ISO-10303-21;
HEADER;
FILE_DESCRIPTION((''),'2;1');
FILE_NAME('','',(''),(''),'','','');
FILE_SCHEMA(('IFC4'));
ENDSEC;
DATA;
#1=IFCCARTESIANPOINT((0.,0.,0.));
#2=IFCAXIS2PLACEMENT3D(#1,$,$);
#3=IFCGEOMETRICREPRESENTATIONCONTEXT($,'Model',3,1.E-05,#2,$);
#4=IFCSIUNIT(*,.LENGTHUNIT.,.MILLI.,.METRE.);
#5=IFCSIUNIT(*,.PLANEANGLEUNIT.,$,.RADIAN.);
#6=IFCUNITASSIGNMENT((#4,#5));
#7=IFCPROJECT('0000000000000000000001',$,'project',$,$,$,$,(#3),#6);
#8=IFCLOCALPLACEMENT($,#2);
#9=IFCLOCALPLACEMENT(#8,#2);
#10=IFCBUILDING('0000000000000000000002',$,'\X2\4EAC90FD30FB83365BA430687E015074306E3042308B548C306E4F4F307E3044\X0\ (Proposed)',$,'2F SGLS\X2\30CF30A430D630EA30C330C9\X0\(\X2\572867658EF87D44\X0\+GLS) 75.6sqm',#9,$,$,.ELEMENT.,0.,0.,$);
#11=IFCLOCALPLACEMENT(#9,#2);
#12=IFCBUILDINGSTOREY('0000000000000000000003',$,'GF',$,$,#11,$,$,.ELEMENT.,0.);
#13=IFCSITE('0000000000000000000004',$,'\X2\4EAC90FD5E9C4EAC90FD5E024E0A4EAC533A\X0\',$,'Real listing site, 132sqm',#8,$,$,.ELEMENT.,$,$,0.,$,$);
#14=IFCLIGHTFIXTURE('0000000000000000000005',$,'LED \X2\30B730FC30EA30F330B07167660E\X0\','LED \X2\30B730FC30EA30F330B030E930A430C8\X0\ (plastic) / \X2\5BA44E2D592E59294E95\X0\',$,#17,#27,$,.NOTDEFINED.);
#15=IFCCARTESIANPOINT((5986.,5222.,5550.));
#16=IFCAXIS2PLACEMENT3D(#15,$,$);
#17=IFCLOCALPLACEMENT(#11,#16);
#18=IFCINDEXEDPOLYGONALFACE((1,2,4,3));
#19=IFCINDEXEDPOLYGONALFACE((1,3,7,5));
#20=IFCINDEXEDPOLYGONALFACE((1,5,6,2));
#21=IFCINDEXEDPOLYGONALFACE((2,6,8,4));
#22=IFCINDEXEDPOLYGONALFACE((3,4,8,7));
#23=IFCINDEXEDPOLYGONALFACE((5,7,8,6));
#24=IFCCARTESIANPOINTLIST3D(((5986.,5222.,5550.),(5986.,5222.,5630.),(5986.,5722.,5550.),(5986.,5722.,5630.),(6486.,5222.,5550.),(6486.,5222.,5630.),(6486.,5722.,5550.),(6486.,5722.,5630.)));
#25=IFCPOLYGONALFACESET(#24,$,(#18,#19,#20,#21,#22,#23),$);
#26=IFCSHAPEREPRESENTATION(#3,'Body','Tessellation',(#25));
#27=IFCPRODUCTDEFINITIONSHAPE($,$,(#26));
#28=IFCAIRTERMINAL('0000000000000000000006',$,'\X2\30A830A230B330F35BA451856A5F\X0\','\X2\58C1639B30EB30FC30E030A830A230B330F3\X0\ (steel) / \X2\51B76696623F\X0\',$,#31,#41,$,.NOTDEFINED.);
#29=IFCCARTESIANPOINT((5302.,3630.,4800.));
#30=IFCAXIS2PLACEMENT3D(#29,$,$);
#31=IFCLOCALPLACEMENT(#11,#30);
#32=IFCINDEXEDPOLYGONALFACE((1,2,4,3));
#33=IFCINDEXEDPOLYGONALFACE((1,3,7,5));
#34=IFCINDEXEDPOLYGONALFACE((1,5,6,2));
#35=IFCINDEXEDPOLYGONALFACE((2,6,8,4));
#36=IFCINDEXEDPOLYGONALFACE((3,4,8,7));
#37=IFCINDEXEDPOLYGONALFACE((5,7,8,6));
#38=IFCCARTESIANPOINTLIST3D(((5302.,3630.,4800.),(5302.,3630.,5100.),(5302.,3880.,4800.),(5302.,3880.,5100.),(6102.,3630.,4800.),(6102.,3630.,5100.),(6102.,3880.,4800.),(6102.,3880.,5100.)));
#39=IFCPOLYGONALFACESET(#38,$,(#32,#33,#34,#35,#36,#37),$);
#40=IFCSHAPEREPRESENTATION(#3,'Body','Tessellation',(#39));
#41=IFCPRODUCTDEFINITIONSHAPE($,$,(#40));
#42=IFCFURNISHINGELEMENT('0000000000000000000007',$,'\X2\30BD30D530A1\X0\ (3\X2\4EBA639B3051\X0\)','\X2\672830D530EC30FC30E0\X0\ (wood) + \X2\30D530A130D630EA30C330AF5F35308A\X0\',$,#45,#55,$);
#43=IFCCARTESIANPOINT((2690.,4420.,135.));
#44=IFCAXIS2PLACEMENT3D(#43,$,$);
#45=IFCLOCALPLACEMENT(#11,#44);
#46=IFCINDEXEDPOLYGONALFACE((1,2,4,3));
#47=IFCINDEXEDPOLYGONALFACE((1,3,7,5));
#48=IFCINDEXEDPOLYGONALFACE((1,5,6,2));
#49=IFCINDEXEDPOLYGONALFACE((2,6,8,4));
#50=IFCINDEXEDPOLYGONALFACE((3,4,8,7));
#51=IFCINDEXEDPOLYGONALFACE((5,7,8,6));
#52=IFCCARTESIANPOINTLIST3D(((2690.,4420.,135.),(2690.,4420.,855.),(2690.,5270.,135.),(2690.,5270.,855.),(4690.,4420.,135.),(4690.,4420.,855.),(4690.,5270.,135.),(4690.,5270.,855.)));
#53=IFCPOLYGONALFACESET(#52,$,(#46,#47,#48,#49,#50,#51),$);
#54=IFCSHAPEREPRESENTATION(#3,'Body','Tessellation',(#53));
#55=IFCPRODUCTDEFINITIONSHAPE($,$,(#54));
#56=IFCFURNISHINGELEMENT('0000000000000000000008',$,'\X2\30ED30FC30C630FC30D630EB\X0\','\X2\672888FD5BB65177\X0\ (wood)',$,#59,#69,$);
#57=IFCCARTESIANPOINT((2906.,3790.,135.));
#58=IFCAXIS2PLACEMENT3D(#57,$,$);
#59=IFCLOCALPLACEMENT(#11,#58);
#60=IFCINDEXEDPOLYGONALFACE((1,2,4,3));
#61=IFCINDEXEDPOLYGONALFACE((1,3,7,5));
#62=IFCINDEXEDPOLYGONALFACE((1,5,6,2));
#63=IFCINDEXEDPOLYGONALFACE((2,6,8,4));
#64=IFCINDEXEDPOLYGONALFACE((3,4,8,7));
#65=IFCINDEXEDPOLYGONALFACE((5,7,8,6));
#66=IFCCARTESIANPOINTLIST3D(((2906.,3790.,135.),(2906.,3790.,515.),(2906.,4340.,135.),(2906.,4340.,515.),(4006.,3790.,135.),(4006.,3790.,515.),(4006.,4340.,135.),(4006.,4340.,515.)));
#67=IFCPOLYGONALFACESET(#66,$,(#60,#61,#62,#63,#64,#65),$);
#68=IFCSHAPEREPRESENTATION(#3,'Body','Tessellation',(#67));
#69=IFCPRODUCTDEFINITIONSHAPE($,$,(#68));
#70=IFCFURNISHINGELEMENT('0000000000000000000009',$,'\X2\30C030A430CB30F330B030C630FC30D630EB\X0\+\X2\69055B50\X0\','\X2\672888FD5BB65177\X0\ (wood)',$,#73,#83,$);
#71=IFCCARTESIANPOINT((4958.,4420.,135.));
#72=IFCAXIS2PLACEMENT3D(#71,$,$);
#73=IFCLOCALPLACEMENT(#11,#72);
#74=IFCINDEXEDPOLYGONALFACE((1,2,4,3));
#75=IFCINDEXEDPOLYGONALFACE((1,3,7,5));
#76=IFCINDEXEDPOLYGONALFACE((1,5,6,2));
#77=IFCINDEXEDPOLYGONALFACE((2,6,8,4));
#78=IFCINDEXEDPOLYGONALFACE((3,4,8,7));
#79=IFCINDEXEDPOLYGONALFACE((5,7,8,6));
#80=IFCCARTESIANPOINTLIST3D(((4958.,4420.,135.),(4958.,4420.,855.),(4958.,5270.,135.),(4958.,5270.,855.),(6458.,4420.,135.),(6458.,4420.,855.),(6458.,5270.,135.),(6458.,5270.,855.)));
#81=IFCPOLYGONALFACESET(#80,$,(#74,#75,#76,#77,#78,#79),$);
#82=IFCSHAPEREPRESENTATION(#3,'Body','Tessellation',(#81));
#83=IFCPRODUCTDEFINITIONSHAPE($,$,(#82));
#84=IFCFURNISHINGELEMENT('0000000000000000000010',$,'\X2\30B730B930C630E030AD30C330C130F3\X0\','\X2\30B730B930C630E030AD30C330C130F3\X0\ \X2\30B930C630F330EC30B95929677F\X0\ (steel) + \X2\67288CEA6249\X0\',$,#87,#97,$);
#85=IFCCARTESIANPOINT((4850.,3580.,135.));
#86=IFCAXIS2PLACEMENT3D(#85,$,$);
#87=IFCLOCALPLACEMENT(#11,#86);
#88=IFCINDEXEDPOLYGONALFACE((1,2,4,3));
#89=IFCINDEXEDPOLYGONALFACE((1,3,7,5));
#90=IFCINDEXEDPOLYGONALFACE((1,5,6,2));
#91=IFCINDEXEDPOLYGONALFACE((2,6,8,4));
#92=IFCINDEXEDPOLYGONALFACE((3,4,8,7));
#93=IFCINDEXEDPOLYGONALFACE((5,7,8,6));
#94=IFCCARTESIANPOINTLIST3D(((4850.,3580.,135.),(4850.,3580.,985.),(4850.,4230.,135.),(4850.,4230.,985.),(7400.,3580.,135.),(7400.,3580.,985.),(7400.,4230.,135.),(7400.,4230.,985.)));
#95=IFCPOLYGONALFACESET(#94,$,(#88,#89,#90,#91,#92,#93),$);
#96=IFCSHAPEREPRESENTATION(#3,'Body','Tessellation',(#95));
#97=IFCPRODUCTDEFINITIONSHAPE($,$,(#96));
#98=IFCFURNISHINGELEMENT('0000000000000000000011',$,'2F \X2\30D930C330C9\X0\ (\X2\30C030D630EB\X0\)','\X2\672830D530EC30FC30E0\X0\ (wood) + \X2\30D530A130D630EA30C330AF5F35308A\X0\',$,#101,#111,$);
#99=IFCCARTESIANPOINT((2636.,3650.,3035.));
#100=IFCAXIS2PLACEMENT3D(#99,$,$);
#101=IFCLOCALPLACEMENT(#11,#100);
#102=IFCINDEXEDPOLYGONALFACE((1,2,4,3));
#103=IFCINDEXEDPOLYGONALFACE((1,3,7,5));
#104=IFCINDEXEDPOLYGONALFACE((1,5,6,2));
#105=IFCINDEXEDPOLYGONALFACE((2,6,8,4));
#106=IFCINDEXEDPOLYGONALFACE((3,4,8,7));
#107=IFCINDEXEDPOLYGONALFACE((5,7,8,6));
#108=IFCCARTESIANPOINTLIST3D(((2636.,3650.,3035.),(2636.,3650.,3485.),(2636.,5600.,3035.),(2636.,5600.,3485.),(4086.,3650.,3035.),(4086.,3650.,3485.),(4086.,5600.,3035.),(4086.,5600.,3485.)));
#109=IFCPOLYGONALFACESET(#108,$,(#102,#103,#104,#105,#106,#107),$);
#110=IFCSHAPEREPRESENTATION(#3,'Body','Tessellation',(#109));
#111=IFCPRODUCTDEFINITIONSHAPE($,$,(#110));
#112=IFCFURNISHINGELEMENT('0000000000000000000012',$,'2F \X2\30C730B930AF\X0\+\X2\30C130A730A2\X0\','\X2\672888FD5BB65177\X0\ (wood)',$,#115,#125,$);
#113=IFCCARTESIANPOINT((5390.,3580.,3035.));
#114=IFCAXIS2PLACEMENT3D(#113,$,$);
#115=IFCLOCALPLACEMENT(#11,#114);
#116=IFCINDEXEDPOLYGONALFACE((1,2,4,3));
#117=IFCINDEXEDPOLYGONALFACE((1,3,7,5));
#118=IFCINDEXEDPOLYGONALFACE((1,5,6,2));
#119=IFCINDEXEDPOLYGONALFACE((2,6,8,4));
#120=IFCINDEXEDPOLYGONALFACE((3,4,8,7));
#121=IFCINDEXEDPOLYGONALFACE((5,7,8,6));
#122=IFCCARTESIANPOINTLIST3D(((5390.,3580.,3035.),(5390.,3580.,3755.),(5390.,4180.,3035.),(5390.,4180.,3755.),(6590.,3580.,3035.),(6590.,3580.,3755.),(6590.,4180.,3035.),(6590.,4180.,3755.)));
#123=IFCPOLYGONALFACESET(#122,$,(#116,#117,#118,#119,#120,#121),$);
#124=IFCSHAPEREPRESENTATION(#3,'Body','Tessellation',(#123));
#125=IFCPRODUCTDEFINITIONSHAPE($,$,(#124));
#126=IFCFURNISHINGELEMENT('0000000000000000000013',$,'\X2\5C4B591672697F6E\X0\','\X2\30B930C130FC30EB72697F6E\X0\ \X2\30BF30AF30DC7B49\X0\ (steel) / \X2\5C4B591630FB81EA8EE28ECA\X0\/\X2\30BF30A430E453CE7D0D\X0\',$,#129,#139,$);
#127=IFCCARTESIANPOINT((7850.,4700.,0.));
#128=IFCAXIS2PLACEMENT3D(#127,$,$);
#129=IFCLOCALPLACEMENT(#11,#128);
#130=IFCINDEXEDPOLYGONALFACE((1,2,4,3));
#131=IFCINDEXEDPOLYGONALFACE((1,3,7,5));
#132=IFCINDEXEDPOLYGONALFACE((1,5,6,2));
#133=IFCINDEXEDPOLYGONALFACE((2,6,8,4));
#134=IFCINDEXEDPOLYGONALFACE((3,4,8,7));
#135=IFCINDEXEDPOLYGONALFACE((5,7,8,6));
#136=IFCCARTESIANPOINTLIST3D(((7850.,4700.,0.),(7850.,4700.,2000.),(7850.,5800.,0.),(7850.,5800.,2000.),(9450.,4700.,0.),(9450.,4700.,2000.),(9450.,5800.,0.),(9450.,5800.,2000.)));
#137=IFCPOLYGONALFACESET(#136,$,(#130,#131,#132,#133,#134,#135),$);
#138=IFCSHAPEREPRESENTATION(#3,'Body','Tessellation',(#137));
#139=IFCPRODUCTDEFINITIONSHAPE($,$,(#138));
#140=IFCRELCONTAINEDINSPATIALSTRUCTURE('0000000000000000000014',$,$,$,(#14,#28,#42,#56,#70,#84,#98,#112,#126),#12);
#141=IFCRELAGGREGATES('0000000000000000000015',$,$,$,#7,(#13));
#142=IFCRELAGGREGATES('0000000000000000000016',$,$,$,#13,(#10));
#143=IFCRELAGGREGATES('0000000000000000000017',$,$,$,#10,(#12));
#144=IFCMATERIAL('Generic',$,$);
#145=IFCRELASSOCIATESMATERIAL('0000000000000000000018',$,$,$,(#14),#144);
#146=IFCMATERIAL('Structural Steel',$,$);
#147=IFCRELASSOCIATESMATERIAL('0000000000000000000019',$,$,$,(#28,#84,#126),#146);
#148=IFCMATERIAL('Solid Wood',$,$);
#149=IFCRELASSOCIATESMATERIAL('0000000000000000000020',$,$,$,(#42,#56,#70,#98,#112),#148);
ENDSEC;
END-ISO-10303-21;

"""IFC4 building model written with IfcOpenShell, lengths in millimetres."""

from ifc_helpers import new_model, si_unit, frame, frame_2d, origin, place, context, project, spatial, rectangle, extrude, material, element, save


model = new_model("IFC4")

# Units and contexts
model_context = context("Model", 3, precision=1e-05, world=origin())
ifc_project = project(units=[si_unit("LENGTHUNIT", "METRE", prefix="MILLI"), si_unit("PLANEANGLEUNIT", "RADIAN")], contexts=[model_context])

# Site, building, storey
site_placement = place(None, origin())
site = spatial("IfcSite", under=ifc_project, at=site_placement, Name="京都府京都市上京区", ObjectType="Real listing site, 132sqm", CompositionType="ELEMENT", RefElevation=0.0)
building_placement = place(site_placement, origin())
building = spatial("IfcBuilding", under=site, at=building_placement, Name="京都・茶室と縁側のある和の住まい (Proposed)", ObjectType="2F SGLSハイブリッド(在来軸組+GLS) 75.6sqm", CompositionType="ELEMENT", ElevationOfRefHeight=0.0, ElevationOfTerrain=0.0)
storey_placement = place(building_placement, origin())
storey = spatial("IfcBuildingStorey", under=building, at=storey_placement, Name="GF", CompositionType="ELEMENT", Elevation=0.0)

# Shared definitions
ifc_material_1 = material(Name="Solid Wood")

# Shared definitions
ifc_material_2 = material(Name="Generic")

# Shared definitions
ifc_material_3 = material(Name="Structural Steel")

# Light fixture
light_fixture_placement = place(storey_placement, frame((5986.0, 5222.0, 5550.0)))
element("IfcLightFixture", 1, at=light_fixture_placement, inside=storey, material=ifc_material_2, Name="LED シーリング照明", Description="LED シーリングライト (plastic) / 室中央天井", PredefinedType="NOTDEFINED", context=model_context, shape_type="SweptSolid", body=[
    extrude(rectangle(XDim=500.0, YDim=500.0, at=frame_2d((250.0, 250.0))), frame((5986.0, 5222.0, 5550.0)), (0.0, 0.0, 1.0), 80.0),
])

# Air terminal
air_terminal_1_placement = place(storey_placement, frame((5302.0, 3630.0, 4800.0)))
element("IfcAirTerminal", 2, at=air_terminal_1_placement, inside=storey, material=ifc_material_3, Name="エアコン室内機", Description="壁掛ルームエアコン (steel) / 冷暖房", PredefinedType="NOTDEFINED", context=model_context, shape_type="SweptSolid", body=[
    extrude(rectangle(XDim=800.0, YDim=250.0, at=frame_2d((400.0, 125.0))), frame((5302.0, 3630.0, 4800.0)), (0.0, 0.0, 1.0), 300.0),
])

# Furnishing elements
furnishing_1_placement = place(storey_placement, frame((2690.0, 4420.0, 135.0)))
element("IfcFurnishingElement", 3, at=furnishing_1_placement, inside=storey, material=ifc_material_1, Name="ソファ (3人掛け)", Description="木フレーム (wood) + ファブリック張り", context=model_context, shape_type="SweptSolid", body=[
    extrude(rectangle(XDim=2000.0, YDim=850.0, at=frame_2d((1000.0, 425.0))), frame((2690.0, 4420.0, 135.0)), (0.0, 0.0, 1.0), 720.0),
])
furnishing_2_placement = place(storey_placement, frame((2906.0, 3790.0, 135.0)))
element("IfcFurnishingElement", 4, at=furnishing_2_placement, inside=storey, material=ifc_material_1, Name="ローテーブル", Description="木製家具 (wood)", context=model_context, shape_type="SweptSolid", body=[
    extrude(rectangle(XDim=1100.0, YDim=550.0, at=frame_2d((550.0, 275.0))), frame((2906.0, 3790.0, 135.0)), (0.0, 0.0, 1.0), 380.0),
])
furnishing_3_placement = place(storey_placement, frame((4958.0, 4420.0, 135.0)))
element("IfcFurnishingElement", 5, at=furnishing_3_placement, inside=storey, material=ifc_material_1, Name="ダイニングテーブル+椅子", Description="木製家具 (wood)", context=model_context, shape_type="SweptSolid", body=[
    extrude(rectangle(XDim=1500.0, YDim=850.0, at=frame_2d((750.0, 425.0))), frame((4958.0, 4420.0, 135.0)), (0.0, 0.0, 1.0), 720.0),
])
furnishing_4_placement = place(storey_placement, frame((4850.0, 3580.0, 135.0)))
element("IfcFurnishingElement", 6, at=furnishing_4_placement, inside=storey, material=ifc_material_3, Name="システムキッチン", Description="システムキッチン ステンレス天板 (steel) + 木質扉", context=model_context, shape_type="SweptSolid", body=[
    extrude(rectangle(XDim=2550.0, YDim=650.0, at=frame_2d((1275.0, 325.0))), frame((4850.0, 3580.0, 135.0)), (0.0, 0.0, 1.0), 850.0),
])
furnishing_5_placement = place(storey_placement, frame((2636.0, 3650.0, 3035.0)))
element("IfcFurnishingElement", 7, at=furnishing_5_placement, inside=storey, material=ifc_material_1, Name="2F ベッド (ダブル)", Description="木フレーム (wood) + ファブリック張り", context=model_context, shape_type="SweptSolid", body=[
    extrude(rectangle(XDim=1450.0, YDim=1950.0, at=frame_2d((725.0, 975.0))), frame((2636.0, 3650.0, 3035.0)), (0.0, 0.0, 1.0), 450.0),
])
furnishing_6_placement = place(storey_placement, frame((5390.0, 3580.0, 3035.0)))
element("IfcFurnishingElement", 8, at=furnishing_6_placement, inside=storey, material=ifc_material_1, Name="2F デスク+チェア", Description="木製家具 (wood)", context=model_context, shape_type="SweptSolid", body=[
    extrude(rectangle(XDim=1200.0, YDim=600.0, at=frame_2d((600.0, 300.0))), frame((5390.0, 3580.0, 3035.0)), (0.0, 0.0, 1.0), 720.0),
])
furnishing_7_placement = place(storey_placement, frame((7850.0, 4700.0, 0.0)))
element("IfcFurnishingElement", 9, at=furnishing_7_placement, inside=storey, material=ifc_material_3, Name="屋外物置", Description="スチール物置 タクボ等 (steel) / 屋外・自転車/タイヤ収納", context=model_context, shape_type="SweptSolid", body=[
    extrude(rectangle(XDim=1600.0, YDim=1100.0, at=frame_2d((800.0, 550.0))), frame((7850.0, 4700.0, 0.0)), (0.0, 0.0, 1.0), 2000.0),
])

save(model, "model.ifc")
